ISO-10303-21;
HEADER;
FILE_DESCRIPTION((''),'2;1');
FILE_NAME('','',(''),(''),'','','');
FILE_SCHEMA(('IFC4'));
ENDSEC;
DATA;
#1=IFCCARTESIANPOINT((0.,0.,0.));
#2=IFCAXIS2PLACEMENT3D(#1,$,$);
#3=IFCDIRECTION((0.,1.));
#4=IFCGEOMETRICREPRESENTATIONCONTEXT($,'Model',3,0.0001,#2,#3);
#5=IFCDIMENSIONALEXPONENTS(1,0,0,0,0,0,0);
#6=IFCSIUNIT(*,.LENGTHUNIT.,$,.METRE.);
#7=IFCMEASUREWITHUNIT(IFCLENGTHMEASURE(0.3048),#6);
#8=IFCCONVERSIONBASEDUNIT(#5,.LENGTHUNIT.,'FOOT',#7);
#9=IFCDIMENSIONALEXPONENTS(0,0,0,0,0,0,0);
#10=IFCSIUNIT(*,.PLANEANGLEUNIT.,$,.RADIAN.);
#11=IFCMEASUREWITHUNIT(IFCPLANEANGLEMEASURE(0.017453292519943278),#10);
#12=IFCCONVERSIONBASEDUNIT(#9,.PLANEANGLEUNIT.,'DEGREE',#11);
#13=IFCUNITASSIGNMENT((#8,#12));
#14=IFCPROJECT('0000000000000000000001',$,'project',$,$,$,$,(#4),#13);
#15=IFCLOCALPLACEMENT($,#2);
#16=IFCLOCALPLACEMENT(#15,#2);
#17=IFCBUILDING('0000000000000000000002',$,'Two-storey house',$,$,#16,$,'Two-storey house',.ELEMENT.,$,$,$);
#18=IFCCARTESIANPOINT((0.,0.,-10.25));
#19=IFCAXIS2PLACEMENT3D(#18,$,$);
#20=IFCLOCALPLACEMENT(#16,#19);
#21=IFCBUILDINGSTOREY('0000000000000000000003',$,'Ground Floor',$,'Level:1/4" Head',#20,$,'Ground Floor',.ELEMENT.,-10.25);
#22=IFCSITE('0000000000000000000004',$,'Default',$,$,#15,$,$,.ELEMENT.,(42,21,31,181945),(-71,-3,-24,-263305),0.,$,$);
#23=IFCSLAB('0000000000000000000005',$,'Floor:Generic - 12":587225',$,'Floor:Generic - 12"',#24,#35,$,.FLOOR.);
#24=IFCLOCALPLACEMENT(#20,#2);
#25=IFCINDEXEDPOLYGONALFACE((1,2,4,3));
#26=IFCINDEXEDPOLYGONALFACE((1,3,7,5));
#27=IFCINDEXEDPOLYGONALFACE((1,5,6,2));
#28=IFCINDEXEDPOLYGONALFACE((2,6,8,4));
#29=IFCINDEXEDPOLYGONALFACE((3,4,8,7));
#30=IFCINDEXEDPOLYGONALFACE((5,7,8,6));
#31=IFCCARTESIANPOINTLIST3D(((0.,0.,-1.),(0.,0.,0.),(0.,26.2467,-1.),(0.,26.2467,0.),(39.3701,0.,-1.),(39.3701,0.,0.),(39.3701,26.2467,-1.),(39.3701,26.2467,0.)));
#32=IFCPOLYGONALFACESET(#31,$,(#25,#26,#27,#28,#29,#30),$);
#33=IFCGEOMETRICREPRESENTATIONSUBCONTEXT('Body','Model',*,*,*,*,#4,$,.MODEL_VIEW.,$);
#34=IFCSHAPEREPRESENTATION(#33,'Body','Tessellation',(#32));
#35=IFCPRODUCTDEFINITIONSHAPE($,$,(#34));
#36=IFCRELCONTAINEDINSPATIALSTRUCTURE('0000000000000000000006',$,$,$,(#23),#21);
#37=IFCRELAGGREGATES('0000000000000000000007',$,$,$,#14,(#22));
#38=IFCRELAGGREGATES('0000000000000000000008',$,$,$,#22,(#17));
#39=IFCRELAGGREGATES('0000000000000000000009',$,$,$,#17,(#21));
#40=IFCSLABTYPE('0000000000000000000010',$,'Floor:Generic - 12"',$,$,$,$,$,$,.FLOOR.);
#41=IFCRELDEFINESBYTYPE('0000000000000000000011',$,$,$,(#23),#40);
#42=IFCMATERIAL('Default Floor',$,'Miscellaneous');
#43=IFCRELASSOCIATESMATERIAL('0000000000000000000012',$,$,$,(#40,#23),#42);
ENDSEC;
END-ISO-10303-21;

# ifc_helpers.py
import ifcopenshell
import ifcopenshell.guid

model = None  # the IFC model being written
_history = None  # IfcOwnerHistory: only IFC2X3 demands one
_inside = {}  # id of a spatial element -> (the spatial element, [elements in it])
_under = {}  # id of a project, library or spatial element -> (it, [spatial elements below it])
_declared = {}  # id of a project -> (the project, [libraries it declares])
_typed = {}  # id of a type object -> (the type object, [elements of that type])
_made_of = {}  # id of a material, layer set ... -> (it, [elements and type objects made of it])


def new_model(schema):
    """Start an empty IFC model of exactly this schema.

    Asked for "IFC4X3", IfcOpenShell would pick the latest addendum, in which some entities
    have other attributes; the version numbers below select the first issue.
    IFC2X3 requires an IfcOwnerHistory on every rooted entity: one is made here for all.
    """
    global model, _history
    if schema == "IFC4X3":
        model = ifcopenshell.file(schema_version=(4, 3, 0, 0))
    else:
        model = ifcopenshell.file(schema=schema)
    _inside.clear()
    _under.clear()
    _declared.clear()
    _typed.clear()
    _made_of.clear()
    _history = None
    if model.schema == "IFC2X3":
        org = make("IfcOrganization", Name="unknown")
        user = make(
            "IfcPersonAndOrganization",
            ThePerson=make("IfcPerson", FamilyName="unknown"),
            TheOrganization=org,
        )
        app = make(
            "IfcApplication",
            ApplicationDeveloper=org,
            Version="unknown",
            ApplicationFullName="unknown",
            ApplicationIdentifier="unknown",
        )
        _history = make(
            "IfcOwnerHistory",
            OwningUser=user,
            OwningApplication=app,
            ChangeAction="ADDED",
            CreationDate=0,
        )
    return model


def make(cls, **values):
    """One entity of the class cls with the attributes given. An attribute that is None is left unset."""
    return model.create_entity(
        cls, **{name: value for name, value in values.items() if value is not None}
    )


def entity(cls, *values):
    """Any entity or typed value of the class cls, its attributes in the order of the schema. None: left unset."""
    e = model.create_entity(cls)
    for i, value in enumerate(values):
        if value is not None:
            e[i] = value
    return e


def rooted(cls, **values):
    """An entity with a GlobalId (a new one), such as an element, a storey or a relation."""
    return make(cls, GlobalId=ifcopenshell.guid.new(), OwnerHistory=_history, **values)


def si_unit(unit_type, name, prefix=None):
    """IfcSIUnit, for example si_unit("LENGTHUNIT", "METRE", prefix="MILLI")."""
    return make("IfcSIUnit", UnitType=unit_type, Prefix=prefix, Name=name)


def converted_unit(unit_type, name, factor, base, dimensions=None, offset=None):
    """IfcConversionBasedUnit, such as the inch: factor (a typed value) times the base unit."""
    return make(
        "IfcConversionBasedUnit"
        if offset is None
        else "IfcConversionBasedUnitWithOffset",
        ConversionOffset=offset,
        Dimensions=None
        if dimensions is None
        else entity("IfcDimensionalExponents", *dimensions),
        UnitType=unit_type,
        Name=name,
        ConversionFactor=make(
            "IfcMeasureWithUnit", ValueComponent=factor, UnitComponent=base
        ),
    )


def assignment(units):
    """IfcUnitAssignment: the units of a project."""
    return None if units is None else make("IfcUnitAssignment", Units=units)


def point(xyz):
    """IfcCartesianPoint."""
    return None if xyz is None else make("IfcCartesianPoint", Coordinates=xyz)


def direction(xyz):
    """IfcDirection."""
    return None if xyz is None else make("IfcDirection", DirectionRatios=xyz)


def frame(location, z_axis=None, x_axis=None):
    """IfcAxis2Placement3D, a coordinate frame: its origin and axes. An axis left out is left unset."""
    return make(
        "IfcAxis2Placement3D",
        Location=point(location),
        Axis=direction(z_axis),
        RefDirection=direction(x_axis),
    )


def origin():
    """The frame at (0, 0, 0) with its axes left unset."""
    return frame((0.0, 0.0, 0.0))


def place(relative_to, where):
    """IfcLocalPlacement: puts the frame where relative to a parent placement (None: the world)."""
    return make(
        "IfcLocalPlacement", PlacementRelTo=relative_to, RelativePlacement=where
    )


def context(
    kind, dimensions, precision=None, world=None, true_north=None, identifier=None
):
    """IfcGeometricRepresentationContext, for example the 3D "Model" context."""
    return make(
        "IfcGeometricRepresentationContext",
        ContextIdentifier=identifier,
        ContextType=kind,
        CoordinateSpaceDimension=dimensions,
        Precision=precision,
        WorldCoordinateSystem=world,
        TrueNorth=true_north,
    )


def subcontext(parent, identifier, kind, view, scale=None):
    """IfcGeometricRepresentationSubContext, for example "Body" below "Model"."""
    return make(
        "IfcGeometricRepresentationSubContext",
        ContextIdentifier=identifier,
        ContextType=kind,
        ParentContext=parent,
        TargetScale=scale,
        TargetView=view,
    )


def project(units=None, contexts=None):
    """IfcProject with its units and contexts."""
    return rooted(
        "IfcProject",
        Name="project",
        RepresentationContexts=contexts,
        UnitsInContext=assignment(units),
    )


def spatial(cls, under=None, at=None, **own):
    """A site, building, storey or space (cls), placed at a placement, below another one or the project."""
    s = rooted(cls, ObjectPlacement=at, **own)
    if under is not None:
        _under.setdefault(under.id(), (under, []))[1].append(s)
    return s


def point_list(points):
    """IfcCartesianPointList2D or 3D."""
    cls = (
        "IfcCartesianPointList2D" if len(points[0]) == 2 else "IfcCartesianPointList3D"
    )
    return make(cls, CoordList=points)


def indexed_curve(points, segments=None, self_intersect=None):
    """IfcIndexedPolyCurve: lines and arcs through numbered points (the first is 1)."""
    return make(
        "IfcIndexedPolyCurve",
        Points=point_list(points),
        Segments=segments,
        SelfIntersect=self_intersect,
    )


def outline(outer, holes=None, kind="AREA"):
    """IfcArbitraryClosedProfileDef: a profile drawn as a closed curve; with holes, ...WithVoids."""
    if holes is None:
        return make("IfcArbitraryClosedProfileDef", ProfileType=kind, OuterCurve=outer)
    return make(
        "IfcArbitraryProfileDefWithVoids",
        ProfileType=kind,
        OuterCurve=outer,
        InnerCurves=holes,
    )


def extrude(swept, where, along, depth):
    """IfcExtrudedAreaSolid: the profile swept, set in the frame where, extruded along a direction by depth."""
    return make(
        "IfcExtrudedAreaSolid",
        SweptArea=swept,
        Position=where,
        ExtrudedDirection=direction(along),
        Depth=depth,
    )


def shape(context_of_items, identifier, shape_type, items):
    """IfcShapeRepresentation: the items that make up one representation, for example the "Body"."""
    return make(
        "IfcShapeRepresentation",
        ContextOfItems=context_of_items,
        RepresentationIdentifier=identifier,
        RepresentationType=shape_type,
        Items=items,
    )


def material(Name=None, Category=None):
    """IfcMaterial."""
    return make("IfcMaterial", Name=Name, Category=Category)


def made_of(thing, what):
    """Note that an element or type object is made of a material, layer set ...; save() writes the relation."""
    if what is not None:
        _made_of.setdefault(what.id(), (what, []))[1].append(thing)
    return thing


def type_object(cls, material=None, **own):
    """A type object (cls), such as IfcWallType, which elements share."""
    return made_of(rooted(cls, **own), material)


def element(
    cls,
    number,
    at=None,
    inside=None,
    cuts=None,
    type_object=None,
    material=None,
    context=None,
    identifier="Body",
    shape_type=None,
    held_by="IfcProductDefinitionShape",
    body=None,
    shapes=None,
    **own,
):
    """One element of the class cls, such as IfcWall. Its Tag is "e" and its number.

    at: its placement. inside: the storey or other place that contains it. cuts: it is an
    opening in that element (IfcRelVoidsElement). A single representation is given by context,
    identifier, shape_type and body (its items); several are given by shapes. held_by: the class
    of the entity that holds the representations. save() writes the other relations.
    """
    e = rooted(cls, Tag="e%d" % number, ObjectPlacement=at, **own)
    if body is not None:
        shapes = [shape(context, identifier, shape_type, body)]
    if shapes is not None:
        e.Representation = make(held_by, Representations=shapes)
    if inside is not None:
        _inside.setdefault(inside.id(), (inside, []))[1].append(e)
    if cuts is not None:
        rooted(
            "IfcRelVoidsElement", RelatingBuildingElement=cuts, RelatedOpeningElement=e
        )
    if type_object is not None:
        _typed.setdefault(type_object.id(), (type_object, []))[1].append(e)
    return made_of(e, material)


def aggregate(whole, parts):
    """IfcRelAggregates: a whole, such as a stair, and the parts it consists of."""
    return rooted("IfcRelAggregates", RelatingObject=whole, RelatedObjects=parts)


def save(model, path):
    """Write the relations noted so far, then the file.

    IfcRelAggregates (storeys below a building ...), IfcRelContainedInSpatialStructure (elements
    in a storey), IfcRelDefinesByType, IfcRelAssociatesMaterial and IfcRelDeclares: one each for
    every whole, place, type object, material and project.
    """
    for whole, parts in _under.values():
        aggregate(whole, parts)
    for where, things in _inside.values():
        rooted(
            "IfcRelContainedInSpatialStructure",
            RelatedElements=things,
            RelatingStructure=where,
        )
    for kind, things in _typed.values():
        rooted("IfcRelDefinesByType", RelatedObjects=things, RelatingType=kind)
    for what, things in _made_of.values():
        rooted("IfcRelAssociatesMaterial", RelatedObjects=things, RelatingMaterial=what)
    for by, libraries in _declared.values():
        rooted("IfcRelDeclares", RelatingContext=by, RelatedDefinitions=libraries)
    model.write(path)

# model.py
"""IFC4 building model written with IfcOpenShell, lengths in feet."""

from ifc_helpers import new_model, entity, si_unit, converted_unit, direction, frame, origin, place, context, subcontext, project, spatial, indexed_curve, outline, extrude, material, type_object, element, save


model = new_model("IFC4")

# Units and contexts
model_context = context("Model", 3, precision=0.0001, world=origin(), true_north=direction((0.0, 1.0)))
body_context = subcontext(model_context, "Body", "Model", "MODEL_VIEW")
ifc_project = project(units=[converted_unit("LENGTHUNIT", "FOOT", entity("IfcLengthMeasure", 0.3048), si_unit("LENGTHUNIT", "METRE"), dimensions=[1, 0, 0, 0, 0, 0, 0]), converted_unit("PLANEANGLEUNIT", "DEGREE", entity("IfcPlaneAngleMeasure", 0.017453292519943278), si_unit("PLANEANGLEUNIT", "RADIAN"), dimensions=[0, 0, 0, 0, 0, 0, 0])], contexts=[model_context])

# Site, building, storey
site_placement = place(None, origin())
site = spatial("IfcSite", under=ifc_project, at=site_placement, Name="Default", CompositionType="ELEMENT", RefLatitude=(42, 21, 31, 181945), RefLongitude=(-71, -3, -24, -263305), RefElevation=0.0)
building_placement = place(site_placement, origin())
building = spatial("IfcBuilding", under=site, at=building_placement, Name="Two-storey house", LongName="Two-storey house", CompositionType="ELEMENT")
storey_placement = place(building_placement, frame((0.0, 0.0, -10.25)))
storey = spatial("IfcBuildingStorey", under=building, at=storey_placement, Name="Ground Floor", ObjectType="Level:1/4\" Head", LongName="Ground Floor", CompositionType="ELEMENT", Elevation=-10.25)

# Slab
ifc_material_1 = material(Name="Default Floor", Category="Miscellaneous")
slab_type = type_object("IfcSlabType", Name="Floor:Generic - 12\"", PredefinedType="FLOOR", material=ifc_material_1)
slab_placement = place(storey_placement, origin())
element("IfcSlab", 1, at=slab_placement, inside=storey, type_object=slab_type, material=ifc_material_1, Name="Floor:Generic - 12\":587225", ObjectType="Floor:Generic - 12\"", PredefinedType="FLOOR", context=body_context, shape_type="SweptSolid", body=[
    extrude(outline(indexed_curve([(-13.1234, -19.685), (13.1234, -19.685), (13.1234, 19.685), (-13.1234, 19.685), (-13.1234, -19.685)], self_intersect=False)), frame((19.685, 13.1234, 0.0), z_axis=(0.0, 0.0, -1.0), x_axis=(0.0, 1.0, 0.0)), (0.0, 0.0, 1.0), 1.0),
])

save(model, "model.ifc")
